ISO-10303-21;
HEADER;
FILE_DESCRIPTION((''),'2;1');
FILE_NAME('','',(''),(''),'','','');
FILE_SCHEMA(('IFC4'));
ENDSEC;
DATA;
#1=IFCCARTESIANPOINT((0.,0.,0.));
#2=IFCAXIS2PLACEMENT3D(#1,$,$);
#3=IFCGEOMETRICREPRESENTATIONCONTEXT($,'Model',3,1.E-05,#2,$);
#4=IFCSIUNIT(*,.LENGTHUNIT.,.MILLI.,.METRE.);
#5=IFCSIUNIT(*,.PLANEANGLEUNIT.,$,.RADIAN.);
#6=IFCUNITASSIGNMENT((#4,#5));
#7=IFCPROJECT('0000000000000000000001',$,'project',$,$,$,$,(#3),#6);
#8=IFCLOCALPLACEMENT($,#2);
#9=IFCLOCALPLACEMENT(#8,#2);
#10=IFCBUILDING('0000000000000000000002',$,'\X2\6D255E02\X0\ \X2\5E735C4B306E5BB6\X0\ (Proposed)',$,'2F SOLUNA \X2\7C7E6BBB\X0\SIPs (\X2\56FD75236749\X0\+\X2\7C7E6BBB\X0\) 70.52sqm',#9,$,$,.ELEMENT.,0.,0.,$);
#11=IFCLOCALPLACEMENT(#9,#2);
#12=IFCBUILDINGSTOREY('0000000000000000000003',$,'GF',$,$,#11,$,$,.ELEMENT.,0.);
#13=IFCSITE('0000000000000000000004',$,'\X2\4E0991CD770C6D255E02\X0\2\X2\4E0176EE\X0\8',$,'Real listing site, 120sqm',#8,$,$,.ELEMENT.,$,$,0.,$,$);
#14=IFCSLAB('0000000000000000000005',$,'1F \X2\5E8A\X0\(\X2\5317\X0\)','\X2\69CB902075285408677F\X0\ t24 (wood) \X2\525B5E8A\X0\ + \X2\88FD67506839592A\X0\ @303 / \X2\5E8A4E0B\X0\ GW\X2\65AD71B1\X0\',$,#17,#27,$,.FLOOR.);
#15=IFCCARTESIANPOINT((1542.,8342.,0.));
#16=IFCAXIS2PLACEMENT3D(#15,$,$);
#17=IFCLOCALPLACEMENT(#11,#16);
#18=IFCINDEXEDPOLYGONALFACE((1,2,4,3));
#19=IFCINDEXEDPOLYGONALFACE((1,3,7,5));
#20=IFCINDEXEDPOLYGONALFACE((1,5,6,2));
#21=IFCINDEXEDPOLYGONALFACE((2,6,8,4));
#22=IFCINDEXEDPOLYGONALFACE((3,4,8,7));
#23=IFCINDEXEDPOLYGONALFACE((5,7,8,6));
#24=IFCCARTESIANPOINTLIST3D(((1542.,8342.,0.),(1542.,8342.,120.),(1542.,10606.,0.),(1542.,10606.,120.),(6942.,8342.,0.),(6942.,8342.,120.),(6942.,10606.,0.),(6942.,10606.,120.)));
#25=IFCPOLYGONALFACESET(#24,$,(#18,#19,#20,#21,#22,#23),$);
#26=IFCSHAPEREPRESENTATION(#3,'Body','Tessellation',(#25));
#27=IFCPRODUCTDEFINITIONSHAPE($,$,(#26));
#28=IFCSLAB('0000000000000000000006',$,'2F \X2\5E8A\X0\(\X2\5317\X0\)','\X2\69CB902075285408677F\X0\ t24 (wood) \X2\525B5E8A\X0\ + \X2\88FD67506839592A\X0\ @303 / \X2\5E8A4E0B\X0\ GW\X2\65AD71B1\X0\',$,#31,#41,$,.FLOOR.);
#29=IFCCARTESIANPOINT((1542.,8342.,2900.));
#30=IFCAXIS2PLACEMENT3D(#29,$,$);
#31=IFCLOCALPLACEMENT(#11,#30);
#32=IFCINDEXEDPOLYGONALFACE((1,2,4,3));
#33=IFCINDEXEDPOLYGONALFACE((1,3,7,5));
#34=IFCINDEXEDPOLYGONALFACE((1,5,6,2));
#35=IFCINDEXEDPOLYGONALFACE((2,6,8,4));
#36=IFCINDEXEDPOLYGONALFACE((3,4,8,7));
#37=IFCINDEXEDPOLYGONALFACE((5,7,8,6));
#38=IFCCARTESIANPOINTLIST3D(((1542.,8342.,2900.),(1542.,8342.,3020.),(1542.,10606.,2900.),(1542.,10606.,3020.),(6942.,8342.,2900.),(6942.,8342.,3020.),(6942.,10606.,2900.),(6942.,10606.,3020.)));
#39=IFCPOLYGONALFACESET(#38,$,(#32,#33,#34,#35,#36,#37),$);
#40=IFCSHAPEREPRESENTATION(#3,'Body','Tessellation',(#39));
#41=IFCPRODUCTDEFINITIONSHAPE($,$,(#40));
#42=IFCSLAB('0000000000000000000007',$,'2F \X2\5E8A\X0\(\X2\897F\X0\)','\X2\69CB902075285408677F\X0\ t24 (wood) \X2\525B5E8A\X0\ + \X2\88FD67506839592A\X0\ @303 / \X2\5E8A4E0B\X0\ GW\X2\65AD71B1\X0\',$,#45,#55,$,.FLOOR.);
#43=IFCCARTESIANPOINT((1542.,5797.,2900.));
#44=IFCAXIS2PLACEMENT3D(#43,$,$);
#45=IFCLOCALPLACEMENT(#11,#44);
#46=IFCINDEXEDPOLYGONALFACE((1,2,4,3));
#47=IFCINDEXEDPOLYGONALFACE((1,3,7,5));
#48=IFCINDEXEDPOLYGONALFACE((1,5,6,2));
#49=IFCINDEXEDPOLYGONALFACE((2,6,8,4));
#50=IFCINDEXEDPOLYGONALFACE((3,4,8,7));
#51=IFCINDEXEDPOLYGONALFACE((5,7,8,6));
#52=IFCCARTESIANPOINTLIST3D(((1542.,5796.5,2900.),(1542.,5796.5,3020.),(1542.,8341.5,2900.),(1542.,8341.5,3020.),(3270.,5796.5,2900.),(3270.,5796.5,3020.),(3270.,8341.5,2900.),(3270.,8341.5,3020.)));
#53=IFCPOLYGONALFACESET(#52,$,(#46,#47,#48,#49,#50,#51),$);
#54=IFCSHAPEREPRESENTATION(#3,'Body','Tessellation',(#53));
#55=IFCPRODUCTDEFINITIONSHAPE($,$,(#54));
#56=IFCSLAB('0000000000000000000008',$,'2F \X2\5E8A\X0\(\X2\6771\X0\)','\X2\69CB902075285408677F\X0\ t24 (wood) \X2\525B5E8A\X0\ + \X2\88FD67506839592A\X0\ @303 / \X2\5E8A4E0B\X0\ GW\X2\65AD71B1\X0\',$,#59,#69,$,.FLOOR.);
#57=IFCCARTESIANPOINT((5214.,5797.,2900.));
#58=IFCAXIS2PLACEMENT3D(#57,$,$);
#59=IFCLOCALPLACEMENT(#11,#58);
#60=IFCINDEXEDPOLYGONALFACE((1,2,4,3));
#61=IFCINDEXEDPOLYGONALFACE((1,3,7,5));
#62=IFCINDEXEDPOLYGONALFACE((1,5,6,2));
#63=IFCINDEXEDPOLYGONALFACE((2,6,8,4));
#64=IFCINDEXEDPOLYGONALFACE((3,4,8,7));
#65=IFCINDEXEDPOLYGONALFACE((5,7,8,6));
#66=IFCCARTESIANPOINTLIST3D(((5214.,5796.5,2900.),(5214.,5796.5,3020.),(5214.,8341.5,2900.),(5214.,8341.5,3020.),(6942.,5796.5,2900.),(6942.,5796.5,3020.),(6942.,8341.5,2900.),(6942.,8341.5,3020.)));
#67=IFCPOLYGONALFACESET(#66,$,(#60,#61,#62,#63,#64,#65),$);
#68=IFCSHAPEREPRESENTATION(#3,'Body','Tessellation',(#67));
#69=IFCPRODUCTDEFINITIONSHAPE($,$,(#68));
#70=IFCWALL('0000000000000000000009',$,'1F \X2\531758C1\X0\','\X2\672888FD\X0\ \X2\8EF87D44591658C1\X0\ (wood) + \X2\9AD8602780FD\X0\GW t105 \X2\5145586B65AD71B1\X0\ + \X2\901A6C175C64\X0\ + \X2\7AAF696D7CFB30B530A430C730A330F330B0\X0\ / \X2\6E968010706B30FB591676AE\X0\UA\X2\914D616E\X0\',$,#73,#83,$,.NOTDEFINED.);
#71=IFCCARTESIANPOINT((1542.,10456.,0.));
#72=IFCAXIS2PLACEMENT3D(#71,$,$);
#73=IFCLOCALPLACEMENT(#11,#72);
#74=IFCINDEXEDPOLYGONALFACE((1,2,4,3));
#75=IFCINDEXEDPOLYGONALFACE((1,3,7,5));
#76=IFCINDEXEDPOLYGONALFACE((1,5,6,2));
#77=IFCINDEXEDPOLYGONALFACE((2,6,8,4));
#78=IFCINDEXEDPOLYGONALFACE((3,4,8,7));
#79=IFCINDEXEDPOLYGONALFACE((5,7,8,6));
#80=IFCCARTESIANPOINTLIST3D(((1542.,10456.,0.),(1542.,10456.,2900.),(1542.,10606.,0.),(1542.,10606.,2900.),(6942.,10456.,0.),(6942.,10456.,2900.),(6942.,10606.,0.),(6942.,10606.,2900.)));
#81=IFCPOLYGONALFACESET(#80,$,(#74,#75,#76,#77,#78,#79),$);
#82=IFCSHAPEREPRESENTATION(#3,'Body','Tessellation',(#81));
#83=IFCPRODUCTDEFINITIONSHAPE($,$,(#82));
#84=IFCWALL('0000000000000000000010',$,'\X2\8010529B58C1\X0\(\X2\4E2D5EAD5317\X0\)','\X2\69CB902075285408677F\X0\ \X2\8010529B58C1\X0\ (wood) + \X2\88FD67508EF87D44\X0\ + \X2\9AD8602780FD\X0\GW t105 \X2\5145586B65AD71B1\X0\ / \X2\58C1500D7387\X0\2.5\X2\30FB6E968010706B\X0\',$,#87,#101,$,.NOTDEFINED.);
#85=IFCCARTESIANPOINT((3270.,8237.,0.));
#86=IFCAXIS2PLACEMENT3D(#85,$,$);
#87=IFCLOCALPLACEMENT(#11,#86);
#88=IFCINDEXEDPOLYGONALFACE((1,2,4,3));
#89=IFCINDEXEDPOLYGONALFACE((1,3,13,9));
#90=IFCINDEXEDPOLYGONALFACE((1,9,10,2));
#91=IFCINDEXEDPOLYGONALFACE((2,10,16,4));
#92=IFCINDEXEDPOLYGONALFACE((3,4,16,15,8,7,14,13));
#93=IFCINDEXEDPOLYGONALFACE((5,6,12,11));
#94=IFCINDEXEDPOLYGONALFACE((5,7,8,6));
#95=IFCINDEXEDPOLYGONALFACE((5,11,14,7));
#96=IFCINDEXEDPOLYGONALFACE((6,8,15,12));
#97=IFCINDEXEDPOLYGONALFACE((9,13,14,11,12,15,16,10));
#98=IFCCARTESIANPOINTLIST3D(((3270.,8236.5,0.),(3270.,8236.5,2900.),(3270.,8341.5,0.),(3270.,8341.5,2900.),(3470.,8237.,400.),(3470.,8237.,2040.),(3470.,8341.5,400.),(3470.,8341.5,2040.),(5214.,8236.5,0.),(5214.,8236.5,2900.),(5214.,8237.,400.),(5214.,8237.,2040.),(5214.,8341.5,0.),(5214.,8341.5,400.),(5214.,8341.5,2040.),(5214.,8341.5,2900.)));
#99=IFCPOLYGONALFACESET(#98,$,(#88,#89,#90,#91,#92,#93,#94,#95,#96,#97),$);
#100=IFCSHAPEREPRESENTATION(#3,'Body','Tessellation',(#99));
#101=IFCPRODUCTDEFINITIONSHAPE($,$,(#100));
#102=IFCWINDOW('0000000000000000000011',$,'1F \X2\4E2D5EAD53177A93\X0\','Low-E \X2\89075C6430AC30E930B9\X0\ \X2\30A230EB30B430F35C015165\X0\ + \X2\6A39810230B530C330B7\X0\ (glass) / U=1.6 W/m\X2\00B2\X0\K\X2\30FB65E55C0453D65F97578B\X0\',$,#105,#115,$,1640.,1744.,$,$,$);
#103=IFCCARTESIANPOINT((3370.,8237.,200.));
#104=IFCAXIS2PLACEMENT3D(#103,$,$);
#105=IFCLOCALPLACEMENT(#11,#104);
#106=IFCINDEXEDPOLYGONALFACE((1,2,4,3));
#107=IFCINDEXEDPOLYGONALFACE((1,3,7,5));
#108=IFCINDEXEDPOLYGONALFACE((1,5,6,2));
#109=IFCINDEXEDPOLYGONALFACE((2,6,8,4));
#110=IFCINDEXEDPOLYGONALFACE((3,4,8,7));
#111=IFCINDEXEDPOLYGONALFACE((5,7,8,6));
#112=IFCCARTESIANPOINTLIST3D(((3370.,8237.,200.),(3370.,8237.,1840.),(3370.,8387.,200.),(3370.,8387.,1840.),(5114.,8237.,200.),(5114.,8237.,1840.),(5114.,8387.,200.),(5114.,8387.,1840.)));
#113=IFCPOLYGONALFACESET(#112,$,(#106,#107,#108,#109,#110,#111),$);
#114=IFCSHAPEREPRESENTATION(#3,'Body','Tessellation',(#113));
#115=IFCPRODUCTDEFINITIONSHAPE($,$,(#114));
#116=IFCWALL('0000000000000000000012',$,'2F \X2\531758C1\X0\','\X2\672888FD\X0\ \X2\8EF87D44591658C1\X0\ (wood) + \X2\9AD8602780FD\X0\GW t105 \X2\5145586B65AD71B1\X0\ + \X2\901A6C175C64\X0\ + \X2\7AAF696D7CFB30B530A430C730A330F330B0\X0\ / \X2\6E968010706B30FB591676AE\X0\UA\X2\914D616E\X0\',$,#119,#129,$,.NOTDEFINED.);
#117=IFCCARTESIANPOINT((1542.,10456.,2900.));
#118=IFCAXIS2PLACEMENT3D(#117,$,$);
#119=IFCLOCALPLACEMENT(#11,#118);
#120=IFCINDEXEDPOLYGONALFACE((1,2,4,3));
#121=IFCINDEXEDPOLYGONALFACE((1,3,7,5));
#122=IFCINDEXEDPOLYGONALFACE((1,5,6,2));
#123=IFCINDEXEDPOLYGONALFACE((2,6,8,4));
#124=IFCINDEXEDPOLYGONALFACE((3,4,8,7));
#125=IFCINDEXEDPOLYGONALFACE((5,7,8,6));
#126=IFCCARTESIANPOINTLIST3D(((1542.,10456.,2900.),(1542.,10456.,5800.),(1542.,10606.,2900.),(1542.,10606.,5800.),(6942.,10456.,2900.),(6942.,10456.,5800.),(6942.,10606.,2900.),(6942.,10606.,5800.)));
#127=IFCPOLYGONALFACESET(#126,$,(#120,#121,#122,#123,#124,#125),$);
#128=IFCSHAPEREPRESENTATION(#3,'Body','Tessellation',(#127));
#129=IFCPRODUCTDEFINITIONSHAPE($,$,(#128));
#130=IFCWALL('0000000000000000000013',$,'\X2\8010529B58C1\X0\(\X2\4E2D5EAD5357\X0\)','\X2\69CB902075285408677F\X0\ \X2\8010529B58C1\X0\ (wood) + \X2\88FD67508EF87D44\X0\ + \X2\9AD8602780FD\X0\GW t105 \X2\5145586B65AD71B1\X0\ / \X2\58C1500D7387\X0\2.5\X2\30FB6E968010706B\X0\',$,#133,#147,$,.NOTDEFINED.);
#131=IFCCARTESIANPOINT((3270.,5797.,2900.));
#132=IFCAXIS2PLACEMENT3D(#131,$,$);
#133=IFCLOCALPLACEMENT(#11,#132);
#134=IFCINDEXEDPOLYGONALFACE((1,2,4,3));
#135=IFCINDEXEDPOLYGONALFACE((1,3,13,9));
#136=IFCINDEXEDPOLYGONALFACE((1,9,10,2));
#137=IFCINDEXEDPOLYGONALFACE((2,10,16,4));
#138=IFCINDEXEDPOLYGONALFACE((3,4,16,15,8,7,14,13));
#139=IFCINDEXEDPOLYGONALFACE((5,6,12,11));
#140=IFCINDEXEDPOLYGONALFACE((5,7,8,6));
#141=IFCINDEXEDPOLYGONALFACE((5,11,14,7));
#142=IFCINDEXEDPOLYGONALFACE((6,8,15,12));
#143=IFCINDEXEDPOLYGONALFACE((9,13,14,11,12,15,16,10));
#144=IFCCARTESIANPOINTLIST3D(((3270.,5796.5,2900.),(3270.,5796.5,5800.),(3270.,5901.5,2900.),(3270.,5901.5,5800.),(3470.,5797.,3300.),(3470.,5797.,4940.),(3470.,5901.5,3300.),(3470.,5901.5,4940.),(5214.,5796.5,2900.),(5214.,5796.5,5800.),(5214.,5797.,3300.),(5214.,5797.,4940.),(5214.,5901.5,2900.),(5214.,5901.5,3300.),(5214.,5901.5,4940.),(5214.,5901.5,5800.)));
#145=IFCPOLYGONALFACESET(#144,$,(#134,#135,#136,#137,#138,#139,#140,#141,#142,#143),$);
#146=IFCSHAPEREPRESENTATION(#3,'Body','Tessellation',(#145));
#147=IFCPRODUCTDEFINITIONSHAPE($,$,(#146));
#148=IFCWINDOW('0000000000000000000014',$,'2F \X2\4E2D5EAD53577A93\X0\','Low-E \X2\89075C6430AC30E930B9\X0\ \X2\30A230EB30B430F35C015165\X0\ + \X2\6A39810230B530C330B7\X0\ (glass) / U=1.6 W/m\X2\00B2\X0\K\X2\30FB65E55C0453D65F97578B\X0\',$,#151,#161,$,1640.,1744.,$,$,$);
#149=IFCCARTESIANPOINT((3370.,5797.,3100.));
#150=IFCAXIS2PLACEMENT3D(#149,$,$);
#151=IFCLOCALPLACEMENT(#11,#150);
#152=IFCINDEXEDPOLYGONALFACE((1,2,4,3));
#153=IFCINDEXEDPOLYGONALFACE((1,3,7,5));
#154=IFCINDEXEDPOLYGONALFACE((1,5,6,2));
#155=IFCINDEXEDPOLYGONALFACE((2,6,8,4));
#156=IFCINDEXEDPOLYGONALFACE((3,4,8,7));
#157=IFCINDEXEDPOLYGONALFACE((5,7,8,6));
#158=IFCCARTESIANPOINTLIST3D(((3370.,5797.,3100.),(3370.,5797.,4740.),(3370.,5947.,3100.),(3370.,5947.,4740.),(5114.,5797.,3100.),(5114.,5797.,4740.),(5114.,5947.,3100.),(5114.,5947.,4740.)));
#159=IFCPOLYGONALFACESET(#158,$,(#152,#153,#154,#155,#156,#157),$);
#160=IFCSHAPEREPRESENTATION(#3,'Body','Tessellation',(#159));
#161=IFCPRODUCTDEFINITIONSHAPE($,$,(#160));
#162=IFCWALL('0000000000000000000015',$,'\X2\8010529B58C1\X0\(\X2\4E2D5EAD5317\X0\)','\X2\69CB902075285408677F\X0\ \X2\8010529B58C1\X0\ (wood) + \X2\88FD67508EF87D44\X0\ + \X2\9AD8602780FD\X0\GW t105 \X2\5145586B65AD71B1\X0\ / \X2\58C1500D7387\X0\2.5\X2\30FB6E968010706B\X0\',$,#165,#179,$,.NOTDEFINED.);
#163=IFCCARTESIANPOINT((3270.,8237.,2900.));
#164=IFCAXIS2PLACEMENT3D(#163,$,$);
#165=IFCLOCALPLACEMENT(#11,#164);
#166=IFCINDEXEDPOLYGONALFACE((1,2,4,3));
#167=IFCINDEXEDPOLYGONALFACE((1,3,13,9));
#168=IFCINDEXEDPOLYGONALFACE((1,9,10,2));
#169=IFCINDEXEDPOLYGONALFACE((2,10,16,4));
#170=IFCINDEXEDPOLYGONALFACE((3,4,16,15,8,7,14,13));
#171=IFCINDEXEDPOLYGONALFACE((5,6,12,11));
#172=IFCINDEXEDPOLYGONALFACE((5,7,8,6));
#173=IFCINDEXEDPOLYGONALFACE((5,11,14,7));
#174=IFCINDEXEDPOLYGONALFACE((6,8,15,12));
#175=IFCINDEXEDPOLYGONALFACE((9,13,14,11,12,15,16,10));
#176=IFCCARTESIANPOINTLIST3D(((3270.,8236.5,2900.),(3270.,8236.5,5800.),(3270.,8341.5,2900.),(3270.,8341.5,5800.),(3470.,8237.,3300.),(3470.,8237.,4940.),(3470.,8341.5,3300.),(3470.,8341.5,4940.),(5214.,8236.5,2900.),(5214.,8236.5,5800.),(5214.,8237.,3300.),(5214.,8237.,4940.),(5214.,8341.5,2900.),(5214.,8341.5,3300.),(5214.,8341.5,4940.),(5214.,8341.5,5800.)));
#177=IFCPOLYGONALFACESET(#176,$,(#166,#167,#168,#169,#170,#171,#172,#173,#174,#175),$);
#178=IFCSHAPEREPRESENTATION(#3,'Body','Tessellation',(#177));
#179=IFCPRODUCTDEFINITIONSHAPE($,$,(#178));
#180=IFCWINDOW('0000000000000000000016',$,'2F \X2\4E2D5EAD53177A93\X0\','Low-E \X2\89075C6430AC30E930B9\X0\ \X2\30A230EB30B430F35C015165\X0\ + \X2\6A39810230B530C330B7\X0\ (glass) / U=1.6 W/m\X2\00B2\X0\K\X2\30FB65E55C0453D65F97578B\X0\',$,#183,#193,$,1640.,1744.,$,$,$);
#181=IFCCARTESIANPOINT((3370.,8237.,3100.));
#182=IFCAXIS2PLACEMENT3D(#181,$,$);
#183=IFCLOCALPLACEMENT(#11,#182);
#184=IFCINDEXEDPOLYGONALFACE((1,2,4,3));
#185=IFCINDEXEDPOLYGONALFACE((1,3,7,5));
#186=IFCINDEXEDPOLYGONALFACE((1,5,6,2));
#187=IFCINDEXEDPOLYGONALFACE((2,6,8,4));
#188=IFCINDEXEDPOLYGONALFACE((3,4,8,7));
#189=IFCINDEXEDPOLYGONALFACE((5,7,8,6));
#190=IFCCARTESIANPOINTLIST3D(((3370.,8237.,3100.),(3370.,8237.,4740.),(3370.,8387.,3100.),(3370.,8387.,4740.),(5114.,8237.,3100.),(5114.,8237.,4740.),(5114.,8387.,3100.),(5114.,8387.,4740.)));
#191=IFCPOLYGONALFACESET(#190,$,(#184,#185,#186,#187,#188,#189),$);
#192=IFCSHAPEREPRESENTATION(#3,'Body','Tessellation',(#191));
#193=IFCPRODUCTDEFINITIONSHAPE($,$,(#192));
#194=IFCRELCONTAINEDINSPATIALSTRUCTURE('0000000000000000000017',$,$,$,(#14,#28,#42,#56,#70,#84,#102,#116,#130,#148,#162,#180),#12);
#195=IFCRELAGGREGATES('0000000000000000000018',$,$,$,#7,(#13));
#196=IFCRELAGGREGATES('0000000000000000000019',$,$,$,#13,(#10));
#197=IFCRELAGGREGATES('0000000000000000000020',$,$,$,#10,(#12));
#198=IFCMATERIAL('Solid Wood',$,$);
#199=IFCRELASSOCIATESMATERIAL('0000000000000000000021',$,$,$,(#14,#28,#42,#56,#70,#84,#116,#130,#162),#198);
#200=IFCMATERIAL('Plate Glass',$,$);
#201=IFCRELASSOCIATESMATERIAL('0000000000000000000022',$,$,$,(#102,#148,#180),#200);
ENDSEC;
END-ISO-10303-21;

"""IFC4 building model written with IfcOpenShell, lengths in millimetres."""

from ifc_helpers import new_model, si_unit, frame, frame_2d, origin, place, context, project, spatial, rectangle, extrude, material, element, fill, save


model = new_model("IFC4")

# Units and contexts
model_context = context("Model", 3, precision=1e-05, world=origin())
ifc_project = project(units=[si_unit("LENGTHUNIT", "METRE", prefix="MILLI"), si_unit("PLANEANGLEUNIT", "RADIAN")], contexts=[model_context])

# Site, building, storey
site_placement = place(None, origin())
site = spatial("IfcSite", under=ifc_project, at=site_placement, Name="三重県津市2丁目8", ObjectType="Real listing site, 120sqm", CompositionType="ELEMENT", RefElevation=0.0)
building_placement = place(site_placement, origin())
building = spatial("IfcBuilding", under=site, at=building_placement, Name="津市 平屋の家 (Proposed)", ObjectType="2F SOLUNA 籾殻SIPs (国産杉+籾殻) 70.52sqm", CompositionType="ELEMENT", ElevationOfRefHeight=0.0, ElevationOfTerrain=0.0)
storey_placement = place(building_placement, origin())
storey = spatial("IfcBuildingStorey", under=building, at=storey_placement, Name="GF", CompositionType="ELEMENT", Elevation=0.0)

# Slabs
ifc_material_1 = material(Name="Solid Wood")
slab_1_placement = place(storey_placement, frame((1542.0, 8342.0, 0.0)))
element("IfcSlab", 1, at=slab_1_placement, inside=storey, material=ifc_material_1, Name="1F 床(北)", Description="構造用合板 t24 (wood) 剛床 + 製材根太 @303 / 床下 GW断熱", PredefinedType="FLOOR", context=model_context, shape_type="SweptSolid", body=[
    extrude(rectangle(XDim=5400.0, YDim=2264.0, at=frame_2d((2700.0, 1132.0))), frame((1542.0, 8342.0, 0.0)), (0.0, 0.0, 1.0), 120.0),
])
slab_2_placement = place(storey_placement, frame((1542.0, 8342.0, 2900.0)))
element("IfcSlab", 2, at=slab_2_placement, inside=storey, material=ifc_material_1, Name="2F 床(北)", Description="構造用合板 t24 (wood) 剛床 + 製材根太 @303 / 床下 GW断熱", PredefinedType="FLOOR", context=model_context, shape_type="SweptSolid", body=[
    extrude(rectangle(XDim=5400.0, YDim=2264.0, at=frame_2d((2700.0, 1132.0))), frame((1542.0, 8342.0, 2900.0)), (0.0, 0.0, 1.0), 120.0),
])
slab_3_placement = place(storey_placement, frame((1542.0, 5797.0, 2900.0)))
element("IfcSlab", 3, at=slab_3_placement, inside=storey, material=ifc_material_1, Name="2F 床(西)", Description="構造用合板 t24 (wood) 剛床 + 製材根太 @303 / 床下 GW断熱", PredefinedType="FLOOR", context=model_context, shape_type="SweptSolid", body=[
    extrude(rectangle(XDim=1728.0, YDim=2545.0, at=frame_2d((864.0, 1272.0))), frame((1542.0, 5797.0, 2900.0)), (0.0, 0.0, 1.0), 120.0),
])
slab_4_placement = place(storey_placement, frame((5214.0, 5797.0, 2900.0)))
element("IfcSlab", 4, at=slab_4_placement, inside=storey, material=ifc_material_1, Name="2F 床(東)", Description="構造用合板 t24 (wood) 剛床 + 製材根太 @303 / 床下 GW断熱", PredefinedType="FLOOR", context=model_context, shape_type="SweptSolid", body=[
    extrude(rectangle(XDim=1728.0, YDim=2545.0, at=frame_2d((864.0, 1272.0))), frame((5214.0, 5797.0, 2900.0)), (0.0, 0.0, 1.0), 120.0),
])

# Wall
wall_1_placement = place(storey_placement, frame((1542.0, 10456.0, 0.0)))
element("IfcWall", 5, at=wall_1_placement, inside=storey, material=ifc_material_1, Name="1F 北壁", Description="木製 軸組外壁 (wood) + 高性能GW t105 充填断熱 + 通気層 + 窯業系サイディング / 準耐火・外皮UA配慮", PredefinedType="NOTDEFINED", context=model_context, shape_type="SweptSolid", body=[
    extrude(rectangle(XDim=5400.0, YDim=150.0, at=frame_2d((2700.0, 75.0))), frame((1542.0, 10456.0, 0.0)), (0.0, 0.0, 1.0), 2900.0),
])

# Wall, opening, window
wall_2_placement = place(storey_placement, frame((3270.0, 8237.0, 0.0)))
wall_2 = element("IfcWall", 6, at=wall_2_placement, inside=storey, material=ifc_material_1, Name="耐力壁(中庭北)", Description="構造用合板 耐力壁 (wood) + 製材軸組 + 高性能GW t105 充填断熱 / 壁倍率2.5・準耐火", PredefinedType="NOTDEFINED", context=model_context, shape_type="SweptSolid", body=[
    extrude(rectangle(XDim=1944.0, YDim=105.0, at=frame_2d((972.0, 52.0))), frame((3270.0, 8237.0, 0.0)), (0.0, 0.0, 1.0), 2900.0),
])
opening_1_placement = place(storey_placement, frame((3370.0, 8237.0, 200.0)))
opening_1 = element("IfcOpeningElement", 7, at=opening_1_placement, cuts=wall_2, PredefinedType="NOTDEFINED", context=model_context, shape_type="SweptSolid", body=[
    extrude(rectangle(XDim=1744.0, YDim=150.0, at=frame_2d((872.0, 75.0))), frame((3370.0, 8237.0, 200.0)), (0.0, 0.0, 1.0), 1640.0),
])
ifc_material_2 = material(Name="Plate Glass")
window_1_placement = place(storey_placement, frame((3370.0, 8237.0, 200.0)))
window_1 = element("IfcWindow", 8, at=window_1_placement, inside=storey, material=ifc_material_2, Name="1F 中庭北窓", Description="Low-E 複層ガラス アルゴン封入 + 樹脂サッシ (glass) / U=1.6 W/m²K・日射取得型", OverallHeight=1640.0, OverallWidth=1744.0, context=model_context, shape_type="SweptSolid", body=[
    extrude(rectangle(XDim=1744.0, YDim=150.0, at=frame_2d((872.0, 75.0))), frame((3370.0, 8237.0, 200.0)), (0.0, 0.0, 1.0), 1640.0),
])
fill(opening_1, window_1)

# Wall
wall_3_placement = place(storey_placement, frame((1542.0, 10456.0, 2900.0)))
element("IfcWall", 9, at=wall_3_placement, inside=storey, material=ifc_material_1, Name="2F 北壁", Description="木製 軸組外壁 (wood) + 高性能GW t105 充填断熱 + 通気層 + 窯業系サイディング / 準耐火・外皮UA配慮", PredefinedType="NOTDEFINED", context=model_context, shape_type="SweptSolid", body=[
    extrude(rectangle(XDim=5400.0, YDim=150.0, at=frame_2d((2700.0, 75.0))), frame((1542.0, 10456.0, 2900.0)), (0.0, 0.0, 1.0), 2900.0),
])

# Walls, openings, windows
wall_4_placement = place(storey_placement, frame((3270.0, 5797.0, 2900.0)))
wall_4 = element("IfcWall", 10, at=wall_4_placement, inside=storey, material=ifc_material_1, Name="耐力壁(中庭南)", Description="構造用合板 耐力壁 (wood) + 製材軸組 + 高性能GW t105 充填断熱 / 壁倍率2.5・準耐火", PredefinedType="NOTDEFINED", context=model_context, shape_type="SweptSolid", body=[
    extrude(rectangle(XDim=1944.0, YDim=105.0, at=frame_2d((972.0, 52.0))), frame((3270.0, 5797.0, 2900.0)), (0.0, 0.0, 1.0), 2900.0),
])
opening_2_placement = place(storey_placement, frame((3370.0, 5797.0, 3100.0)))
opening_2 = element("IfcOpeningElement", 11, at=opening_2_placement, cuts=wall_4, PredefinedType="NOTDEFINED", context=model_context, shape_type="SweptSolid", body=[
    extrude(rectangle(XDim=1744.0, YDim=150.0, at=frame_2d((872.0, 75.0))), frame((3370.0, 5797.0, 3100.0)), (0.0, 0.0, 1.0), 1640.0),
])
window_2_placement = place(storey_placement, frame((3370.0, 5797.0, 3100.0)))
window_2 = element("IfcWindow", 12, at=window_2_placement, inside=storey, material=ifc_material_2, Name="2F 中庭南窓", Description="Low-E 複層ガラス アルゴン封入 + 樹脂サッシ (glass) / U=1.6 W/m²K・日射取得型", OverallHeight=1640.0, OverallWidth=1744.0, context=model_context, shape_type="SweptSolid", body=[
    extrude(rectangle(XDim=1744.0, YDim=150.0, at=frame_2d((872.0, 75.0))), frame((3370.0, 5797.0, 3100.0)), (0.0, 0.0, 1.0), 1640.0),
])
fill(opening_2, window_2)
wall_5_placement = place(storey_placement, frame((3270.0, 8237.0, 2900.0)))
wall_5 = element("IfcWall", 13, at=wall_5_placement, inside=storey, material=ifc_material_1, Name="耐力壁(中庭北)", Description="構造用合板 耐力壁 (wood) + 製材軸組 + 高性能GW t105 充填断熱 / 壁倍率2.5・準耐火", PredefinedType="NOTDEFINED", context=model_context, shape_type="SweptSolid", body=[
    extrude(rectangle(XDim=1944.0, YDim=105.0, at=frame_2d((972.0, 52.0))), frame((3270.0, 8237.0, 2900.0)), (0.0, 0.0, 1.0), 2900.0),
])
opening_3_placement = place(storey_placement, frame((3370.0, 8237.0, 3100.0)))
opening_3 = element("IfcOpeningElement", 14, at=opening_3_placement, cuts=wall_5, PredefinedType="NOTDEFINED", context=model_context, shape_type="SweptSolid", body=[
    extrude(rectangle(XDim=1744.0, YDim=150.0, at=frame_2d((872.0, 75.0))), frame((3370.0, 8237.0, 3100.0)), (0.0, 0.0, 1.0), 1640.0),
])
window_3_placement = place(storey_placement, frame((3370.0, 8237.0, 3100.0)))
window_3 = element("IfcWindow", 15, at=window_3_placement, inside=storey, material=ifc_material_2, Name="2F 中庭北窓", Description="Low-E 複層ガラス アルゴン封入 + 樹脂サッシ (glass) / U=1.6 W/m²K・日射取得型", OverallHeight=1640.0, OverallWidth=1744.0, context=model_context, shape_type="SweptSolid", body=[
    extrude(rectangle(XDim=1744.0, YDim=150.0, at=frame_2d((872.0, 75.0))), frame((3370.0, 8237.0, 3100.0)), (0.0, 0.0, 1.0), 1640.0),
])
fill(opening_3, window_3)

save(model, "model.ifc")
